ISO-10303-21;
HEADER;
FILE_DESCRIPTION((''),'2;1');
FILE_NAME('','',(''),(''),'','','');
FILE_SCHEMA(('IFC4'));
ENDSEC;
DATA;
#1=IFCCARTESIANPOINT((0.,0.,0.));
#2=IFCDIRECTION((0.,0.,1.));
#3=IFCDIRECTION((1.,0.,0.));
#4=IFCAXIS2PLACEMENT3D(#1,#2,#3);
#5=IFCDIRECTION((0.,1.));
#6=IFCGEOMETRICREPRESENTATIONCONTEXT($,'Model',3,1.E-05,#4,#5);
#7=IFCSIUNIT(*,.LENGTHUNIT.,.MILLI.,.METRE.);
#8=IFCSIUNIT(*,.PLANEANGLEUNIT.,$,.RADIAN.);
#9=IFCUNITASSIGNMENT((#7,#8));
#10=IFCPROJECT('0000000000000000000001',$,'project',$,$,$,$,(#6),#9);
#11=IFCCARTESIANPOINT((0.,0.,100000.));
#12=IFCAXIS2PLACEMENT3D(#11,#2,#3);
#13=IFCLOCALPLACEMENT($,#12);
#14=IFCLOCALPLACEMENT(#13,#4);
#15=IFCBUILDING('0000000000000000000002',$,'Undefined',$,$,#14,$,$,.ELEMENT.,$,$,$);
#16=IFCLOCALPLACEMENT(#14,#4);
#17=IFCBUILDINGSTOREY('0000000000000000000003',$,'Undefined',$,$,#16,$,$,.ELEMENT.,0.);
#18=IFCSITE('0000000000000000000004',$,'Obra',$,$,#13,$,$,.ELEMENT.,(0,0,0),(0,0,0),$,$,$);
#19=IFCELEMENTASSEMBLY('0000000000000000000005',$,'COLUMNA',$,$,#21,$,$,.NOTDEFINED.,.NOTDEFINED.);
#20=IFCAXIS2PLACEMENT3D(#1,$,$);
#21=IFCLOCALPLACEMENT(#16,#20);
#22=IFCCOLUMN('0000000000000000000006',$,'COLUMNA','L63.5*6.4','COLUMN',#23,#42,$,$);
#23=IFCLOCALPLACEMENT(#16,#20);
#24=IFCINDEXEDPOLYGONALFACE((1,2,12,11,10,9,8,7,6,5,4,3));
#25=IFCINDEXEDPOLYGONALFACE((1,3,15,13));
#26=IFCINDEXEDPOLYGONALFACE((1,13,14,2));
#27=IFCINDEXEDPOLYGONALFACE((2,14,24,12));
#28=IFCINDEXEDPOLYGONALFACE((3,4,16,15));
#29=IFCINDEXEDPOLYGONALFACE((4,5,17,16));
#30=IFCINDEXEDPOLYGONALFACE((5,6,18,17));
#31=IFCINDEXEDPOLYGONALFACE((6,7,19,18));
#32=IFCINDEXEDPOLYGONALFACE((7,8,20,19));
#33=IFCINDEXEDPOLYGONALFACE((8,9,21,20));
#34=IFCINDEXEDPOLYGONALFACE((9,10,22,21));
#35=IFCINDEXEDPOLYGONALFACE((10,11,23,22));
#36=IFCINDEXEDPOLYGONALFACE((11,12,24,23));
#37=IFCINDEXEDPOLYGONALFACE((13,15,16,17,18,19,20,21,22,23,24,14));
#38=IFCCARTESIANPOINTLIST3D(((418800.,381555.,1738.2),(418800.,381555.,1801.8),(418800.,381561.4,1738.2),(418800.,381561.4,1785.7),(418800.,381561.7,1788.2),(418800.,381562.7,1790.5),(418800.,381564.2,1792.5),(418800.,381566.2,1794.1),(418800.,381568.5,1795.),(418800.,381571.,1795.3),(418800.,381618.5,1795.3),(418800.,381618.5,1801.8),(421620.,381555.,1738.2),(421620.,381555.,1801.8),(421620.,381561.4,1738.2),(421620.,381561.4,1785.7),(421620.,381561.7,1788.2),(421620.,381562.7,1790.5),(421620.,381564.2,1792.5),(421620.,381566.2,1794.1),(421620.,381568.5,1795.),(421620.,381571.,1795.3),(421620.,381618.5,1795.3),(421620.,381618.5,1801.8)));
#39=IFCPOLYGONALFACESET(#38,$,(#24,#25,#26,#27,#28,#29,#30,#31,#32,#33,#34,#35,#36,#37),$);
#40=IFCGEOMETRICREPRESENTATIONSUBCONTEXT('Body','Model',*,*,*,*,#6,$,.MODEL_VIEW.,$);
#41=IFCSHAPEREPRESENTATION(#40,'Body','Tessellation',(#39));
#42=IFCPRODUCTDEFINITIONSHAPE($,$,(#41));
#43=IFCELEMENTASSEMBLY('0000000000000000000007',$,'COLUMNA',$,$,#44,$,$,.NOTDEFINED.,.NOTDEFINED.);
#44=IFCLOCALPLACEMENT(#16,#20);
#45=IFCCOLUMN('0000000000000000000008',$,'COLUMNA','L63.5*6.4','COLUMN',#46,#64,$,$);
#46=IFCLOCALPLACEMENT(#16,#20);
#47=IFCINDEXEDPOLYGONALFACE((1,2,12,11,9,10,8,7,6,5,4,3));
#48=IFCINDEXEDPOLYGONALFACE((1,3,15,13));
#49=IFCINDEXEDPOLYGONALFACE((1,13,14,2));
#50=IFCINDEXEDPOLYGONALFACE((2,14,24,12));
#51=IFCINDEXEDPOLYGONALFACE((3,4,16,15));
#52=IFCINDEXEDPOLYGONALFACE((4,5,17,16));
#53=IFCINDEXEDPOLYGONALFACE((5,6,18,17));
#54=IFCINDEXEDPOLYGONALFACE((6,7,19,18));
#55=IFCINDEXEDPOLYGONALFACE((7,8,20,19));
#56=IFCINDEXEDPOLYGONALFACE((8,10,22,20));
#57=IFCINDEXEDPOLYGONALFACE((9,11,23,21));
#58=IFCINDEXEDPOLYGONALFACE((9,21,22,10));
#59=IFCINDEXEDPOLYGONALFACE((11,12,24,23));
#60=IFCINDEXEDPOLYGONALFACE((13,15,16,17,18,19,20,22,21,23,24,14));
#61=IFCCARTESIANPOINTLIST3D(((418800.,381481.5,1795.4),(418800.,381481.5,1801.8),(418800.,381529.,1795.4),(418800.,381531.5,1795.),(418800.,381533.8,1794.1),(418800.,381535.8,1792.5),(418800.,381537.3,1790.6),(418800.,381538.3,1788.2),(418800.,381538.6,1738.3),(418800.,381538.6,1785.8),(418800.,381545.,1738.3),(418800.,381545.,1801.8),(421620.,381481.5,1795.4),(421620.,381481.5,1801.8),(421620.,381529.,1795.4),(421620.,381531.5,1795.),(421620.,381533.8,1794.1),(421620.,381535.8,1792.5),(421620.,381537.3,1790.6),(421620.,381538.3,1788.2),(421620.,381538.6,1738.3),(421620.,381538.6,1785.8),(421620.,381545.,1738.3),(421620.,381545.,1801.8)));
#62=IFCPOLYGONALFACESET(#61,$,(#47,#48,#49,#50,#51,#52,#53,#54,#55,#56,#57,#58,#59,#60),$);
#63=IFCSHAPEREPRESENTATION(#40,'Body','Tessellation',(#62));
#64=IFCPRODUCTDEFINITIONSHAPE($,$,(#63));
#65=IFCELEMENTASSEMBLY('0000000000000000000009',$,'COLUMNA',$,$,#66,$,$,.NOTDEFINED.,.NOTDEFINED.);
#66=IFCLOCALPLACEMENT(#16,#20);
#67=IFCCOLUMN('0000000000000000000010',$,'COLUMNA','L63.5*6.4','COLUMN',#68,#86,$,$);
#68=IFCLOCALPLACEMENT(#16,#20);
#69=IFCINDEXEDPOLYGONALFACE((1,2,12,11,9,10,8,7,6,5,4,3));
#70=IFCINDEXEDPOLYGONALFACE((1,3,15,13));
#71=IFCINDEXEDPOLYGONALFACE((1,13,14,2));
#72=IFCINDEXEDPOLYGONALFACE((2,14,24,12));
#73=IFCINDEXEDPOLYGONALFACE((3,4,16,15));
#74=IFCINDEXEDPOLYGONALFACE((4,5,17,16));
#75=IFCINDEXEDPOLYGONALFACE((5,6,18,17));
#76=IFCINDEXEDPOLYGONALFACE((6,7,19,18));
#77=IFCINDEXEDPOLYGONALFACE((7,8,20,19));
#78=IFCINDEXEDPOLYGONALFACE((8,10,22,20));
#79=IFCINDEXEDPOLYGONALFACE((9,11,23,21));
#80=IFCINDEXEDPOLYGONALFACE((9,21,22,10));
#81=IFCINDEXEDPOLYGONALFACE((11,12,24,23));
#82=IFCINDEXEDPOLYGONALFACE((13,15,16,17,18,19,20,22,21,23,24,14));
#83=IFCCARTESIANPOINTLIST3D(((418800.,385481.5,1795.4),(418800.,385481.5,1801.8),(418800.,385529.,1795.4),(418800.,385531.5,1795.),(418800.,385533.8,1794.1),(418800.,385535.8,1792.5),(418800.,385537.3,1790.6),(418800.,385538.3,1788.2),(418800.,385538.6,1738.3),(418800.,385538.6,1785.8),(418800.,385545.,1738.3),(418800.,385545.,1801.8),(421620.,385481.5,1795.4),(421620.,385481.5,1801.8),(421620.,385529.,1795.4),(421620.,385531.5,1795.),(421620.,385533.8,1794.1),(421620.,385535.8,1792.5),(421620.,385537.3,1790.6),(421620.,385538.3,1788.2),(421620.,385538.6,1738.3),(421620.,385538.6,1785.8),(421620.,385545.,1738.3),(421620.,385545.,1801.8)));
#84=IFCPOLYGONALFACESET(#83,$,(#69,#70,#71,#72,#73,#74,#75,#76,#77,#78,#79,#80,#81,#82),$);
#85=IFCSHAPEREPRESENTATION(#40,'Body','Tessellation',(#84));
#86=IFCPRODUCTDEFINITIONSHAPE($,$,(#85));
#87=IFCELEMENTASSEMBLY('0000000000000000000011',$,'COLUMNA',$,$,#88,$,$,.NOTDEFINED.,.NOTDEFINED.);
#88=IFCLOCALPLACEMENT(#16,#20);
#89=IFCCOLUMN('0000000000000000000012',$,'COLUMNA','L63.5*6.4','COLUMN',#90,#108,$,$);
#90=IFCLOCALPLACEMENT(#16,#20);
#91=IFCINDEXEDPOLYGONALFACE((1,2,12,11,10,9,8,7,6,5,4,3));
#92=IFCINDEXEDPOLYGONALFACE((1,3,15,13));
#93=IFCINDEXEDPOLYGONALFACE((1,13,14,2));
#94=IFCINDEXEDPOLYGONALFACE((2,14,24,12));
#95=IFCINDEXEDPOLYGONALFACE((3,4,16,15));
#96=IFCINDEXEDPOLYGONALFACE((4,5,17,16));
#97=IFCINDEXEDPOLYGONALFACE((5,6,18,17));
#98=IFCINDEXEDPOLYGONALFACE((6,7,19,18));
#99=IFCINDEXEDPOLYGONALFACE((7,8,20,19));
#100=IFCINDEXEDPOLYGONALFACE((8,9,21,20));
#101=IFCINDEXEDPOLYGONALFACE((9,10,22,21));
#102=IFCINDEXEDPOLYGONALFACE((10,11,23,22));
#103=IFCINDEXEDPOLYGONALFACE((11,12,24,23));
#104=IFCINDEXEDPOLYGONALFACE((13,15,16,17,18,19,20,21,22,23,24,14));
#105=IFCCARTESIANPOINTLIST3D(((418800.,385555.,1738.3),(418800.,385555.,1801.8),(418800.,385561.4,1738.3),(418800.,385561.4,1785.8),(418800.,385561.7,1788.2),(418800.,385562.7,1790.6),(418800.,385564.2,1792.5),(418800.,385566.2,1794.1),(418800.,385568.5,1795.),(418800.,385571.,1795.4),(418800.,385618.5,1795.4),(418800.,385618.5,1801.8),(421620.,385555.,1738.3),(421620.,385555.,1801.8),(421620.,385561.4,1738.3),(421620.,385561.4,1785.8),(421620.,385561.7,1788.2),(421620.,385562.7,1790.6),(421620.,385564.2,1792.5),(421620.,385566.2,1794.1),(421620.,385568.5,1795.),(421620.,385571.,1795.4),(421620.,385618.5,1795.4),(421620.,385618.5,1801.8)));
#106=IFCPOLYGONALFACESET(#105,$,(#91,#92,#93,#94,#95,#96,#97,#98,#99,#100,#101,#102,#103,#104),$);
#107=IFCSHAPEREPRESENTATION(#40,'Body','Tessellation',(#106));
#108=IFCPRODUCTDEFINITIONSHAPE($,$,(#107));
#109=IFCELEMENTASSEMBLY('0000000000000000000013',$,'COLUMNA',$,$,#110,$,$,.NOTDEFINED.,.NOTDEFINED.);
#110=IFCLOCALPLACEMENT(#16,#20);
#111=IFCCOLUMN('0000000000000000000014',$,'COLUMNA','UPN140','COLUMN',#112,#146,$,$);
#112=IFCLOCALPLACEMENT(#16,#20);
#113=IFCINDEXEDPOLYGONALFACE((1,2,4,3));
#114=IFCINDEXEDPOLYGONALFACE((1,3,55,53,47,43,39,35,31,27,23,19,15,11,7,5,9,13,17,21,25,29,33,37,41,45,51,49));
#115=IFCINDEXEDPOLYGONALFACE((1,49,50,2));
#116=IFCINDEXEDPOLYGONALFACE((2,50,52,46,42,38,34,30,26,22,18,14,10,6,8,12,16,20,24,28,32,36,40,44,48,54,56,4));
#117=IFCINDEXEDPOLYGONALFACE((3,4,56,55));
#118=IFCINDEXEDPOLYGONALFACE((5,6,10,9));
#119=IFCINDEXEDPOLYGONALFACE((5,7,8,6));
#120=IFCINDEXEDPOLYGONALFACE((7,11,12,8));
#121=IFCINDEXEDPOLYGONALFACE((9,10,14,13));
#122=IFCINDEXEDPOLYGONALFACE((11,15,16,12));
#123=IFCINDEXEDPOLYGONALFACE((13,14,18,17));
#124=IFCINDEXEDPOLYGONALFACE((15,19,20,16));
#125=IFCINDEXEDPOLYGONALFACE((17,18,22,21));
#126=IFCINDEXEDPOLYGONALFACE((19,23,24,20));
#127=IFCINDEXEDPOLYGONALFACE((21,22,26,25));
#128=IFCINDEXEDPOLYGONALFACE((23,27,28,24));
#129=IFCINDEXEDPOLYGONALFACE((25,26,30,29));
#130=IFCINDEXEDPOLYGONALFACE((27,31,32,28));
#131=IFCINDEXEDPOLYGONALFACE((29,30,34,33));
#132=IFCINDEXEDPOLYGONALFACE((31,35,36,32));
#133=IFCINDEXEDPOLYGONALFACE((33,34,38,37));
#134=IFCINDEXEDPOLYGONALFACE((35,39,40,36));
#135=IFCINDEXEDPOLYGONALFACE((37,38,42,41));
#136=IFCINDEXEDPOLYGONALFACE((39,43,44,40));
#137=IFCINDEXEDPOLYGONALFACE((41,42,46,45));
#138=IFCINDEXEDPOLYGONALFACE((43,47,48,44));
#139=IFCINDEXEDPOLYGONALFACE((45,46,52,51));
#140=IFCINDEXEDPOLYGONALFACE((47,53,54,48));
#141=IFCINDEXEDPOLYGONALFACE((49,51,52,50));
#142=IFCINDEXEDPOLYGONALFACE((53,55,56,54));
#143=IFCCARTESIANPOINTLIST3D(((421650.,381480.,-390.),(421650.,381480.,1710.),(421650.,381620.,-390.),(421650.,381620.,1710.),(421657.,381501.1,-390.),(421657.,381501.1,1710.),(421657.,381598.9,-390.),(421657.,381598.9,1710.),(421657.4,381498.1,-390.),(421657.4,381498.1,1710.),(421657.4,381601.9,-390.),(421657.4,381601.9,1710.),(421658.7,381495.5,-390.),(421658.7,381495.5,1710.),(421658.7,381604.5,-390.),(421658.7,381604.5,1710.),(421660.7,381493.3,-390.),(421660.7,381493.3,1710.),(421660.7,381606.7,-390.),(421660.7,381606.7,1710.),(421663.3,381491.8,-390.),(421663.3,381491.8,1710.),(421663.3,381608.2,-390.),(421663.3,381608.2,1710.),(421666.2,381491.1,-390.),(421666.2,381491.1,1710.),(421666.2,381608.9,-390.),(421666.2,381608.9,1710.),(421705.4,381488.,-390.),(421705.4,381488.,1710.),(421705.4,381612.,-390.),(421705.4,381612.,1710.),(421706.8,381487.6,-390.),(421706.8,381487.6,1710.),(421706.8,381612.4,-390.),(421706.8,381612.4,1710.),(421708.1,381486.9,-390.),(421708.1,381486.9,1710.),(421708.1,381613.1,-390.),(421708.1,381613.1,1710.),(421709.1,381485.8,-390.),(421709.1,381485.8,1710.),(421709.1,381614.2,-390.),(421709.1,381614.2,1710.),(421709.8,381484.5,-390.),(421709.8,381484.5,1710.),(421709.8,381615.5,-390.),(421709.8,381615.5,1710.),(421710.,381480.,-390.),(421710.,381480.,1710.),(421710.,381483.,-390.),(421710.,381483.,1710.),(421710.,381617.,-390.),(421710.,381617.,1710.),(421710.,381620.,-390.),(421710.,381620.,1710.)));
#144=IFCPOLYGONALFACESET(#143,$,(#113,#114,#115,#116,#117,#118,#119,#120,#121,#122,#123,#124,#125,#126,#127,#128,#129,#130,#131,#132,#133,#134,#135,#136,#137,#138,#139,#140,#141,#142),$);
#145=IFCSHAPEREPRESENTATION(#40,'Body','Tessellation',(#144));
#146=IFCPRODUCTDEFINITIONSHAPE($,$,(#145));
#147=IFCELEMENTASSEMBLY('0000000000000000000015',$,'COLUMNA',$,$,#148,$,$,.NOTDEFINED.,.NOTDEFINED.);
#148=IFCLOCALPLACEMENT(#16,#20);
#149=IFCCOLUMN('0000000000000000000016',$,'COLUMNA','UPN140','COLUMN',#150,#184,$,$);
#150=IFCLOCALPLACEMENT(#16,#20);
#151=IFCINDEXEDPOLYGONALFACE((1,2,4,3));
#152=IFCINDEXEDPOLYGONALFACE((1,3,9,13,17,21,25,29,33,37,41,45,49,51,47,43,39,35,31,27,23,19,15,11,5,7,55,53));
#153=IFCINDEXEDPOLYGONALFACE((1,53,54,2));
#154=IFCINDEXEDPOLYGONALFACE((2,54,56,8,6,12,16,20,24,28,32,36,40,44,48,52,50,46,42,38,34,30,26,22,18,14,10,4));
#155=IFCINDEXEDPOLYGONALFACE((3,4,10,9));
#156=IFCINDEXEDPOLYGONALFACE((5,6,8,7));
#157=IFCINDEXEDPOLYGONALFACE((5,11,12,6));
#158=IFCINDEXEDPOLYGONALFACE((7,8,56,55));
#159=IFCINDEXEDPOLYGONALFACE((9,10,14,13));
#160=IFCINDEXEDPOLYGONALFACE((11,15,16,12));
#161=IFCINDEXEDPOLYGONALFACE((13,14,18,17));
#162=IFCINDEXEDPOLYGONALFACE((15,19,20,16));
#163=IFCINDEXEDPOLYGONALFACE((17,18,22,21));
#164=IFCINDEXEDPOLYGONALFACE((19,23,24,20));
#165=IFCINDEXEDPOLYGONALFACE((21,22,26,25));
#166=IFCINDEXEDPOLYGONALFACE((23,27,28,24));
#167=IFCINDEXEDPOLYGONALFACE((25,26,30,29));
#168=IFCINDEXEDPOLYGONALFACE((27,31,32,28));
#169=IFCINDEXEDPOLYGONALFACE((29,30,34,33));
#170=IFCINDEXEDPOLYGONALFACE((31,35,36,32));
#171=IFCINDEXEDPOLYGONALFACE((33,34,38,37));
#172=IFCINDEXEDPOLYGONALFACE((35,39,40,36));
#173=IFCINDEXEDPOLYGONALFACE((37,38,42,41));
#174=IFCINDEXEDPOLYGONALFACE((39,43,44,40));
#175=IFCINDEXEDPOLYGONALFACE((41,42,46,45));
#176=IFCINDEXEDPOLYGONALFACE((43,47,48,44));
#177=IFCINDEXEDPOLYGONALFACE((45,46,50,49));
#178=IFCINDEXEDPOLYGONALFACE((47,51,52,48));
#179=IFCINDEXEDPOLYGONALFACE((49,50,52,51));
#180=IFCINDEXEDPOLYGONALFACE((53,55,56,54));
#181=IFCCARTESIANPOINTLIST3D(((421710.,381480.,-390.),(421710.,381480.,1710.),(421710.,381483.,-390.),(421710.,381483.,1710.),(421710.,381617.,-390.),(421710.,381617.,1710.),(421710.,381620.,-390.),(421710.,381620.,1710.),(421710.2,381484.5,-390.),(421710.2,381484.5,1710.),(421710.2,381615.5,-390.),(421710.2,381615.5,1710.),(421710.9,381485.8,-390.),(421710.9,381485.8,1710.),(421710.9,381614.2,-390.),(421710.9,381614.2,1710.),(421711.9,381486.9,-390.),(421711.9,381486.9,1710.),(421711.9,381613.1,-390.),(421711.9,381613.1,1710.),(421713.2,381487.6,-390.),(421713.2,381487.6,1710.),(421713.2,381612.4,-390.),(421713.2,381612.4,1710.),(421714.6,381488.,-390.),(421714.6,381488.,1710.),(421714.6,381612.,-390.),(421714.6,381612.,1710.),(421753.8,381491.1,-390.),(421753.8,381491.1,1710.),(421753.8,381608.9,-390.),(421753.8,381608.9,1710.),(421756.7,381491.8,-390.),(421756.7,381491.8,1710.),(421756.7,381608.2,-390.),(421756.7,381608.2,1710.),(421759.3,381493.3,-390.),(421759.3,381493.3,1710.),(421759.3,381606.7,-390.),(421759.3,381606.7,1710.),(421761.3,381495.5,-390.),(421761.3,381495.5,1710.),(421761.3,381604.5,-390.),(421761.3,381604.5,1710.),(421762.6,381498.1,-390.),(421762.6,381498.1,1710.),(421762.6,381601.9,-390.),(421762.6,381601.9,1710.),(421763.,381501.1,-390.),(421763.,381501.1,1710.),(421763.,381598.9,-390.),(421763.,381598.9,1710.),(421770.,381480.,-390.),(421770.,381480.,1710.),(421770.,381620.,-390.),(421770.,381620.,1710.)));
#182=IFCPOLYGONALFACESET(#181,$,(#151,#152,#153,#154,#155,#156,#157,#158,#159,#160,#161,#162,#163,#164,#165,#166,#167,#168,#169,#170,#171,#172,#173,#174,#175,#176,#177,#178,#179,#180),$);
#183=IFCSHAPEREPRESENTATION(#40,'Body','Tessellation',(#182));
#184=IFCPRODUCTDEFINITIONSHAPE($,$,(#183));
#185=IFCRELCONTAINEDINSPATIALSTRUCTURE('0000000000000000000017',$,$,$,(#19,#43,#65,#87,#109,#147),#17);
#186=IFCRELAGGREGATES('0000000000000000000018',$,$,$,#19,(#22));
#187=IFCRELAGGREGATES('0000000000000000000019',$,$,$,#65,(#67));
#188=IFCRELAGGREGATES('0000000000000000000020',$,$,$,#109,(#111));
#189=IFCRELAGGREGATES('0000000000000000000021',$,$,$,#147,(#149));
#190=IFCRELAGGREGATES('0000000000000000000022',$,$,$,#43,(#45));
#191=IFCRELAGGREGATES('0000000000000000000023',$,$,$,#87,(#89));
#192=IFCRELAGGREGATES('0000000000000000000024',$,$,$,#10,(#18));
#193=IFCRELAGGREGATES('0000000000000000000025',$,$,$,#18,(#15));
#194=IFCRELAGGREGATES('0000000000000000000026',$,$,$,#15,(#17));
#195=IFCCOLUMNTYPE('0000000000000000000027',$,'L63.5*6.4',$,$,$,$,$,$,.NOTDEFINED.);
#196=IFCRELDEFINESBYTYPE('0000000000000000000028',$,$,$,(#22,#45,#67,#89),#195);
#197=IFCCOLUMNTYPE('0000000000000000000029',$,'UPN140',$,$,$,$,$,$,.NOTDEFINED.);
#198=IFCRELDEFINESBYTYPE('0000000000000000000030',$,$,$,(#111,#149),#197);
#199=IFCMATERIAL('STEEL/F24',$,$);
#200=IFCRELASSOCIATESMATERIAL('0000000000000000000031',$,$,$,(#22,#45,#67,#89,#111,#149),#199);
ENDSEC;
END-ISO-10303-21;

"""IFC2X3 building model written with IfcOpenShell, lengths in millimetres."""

from ifc_helpers import new_model, si_unit, direction, frame, origin_with_axes, origin_2d_with_axis, place, context, subcontext, project, spatial, l_section, u_section, extrude, material, type_object, element, aggregate, save


model = new_model("IFC2X3")

# Units and contexts
model_context = context("Model", 3, precision=1e-05, world=origin_with_axes(), true_north=direction((0.0, 1.0)))
body_context = subcontext(model_context, "Body", "Model", "MODEL_VIEW")
ifc_project = project(units=[si_unit("LENGTHUNIT", "METRE", prefix="MILLI"), si_unit("PLANEANGLEUNIT", "RADIAN")], contexts=[model_context])

# Site, building, storey
site_placement = place(None, frame((0.0, 0.0, 100000.0), z_axis=(0.0, 0.0, 1.0), x_axis=(1.0, 0.0, 0.0)))
site = spatial("IfcSite", under=ifc_project, at=site_placement, Name="Obra", CompositionType="ELEMENT", RefLatitude=(0, 0, 0), RefLongitude=(0, 0, 0))
building_placement = place(site_placement, origin_with_axes())
building = spatial("IfcBuilding", under=site, at=building_placement, Name="Undefined", CompositionType="ELEMENT")
storey_placement = place(building_placement, origin_with_axes())
storey = spatial("IfcBuildingStorey", under=building, at=storey_placement, Name="Undefined", CompositionType="ELEMENT", Elevation=0.0)

# Element assemblies, columns
assembly_1_placement = place(storey_placement, origin_with_axes())
assembly_1 = element("IfcElementAssembly", 1, at=assembly_1_placement, inside=storey, Name="COLUMNA", AssemblyPlace="NOTDEFINED", PredefinedType="NOTDEFINED")
ifc_material_1 = material(Name="STEEL/F24")
column_type_1 = type_object("IfcColumnType", Name="L63.5*6.4", PredefinedType="NOTDEFINED")
column_1_placement = place(assembly_1_placement, frame((418800.0, 381586.7, 1770.0), z_axis=(1.0, 0.0, 0.0), x_axis=(0.0, 0.0, -1.0)))
column_1 = element("IfcColumn", 2, at=column_1_placement, type_object=column_type_1, material=ifc_material_1, Name="COLUMNA", Description="L63.5*6.4", ObjectType="COLUMN", context=body_context, shape_type="SweptSolid", body=[
    extrude(l_section(Depth=63.5, Width=63.5, Thickness=6.4, FilletRadius=9.6, at=origin_2d_with_axis()), frame((0.0, 0.0, 2820.0), z_axis=(0.0, 0.0, -1.0), x_axis=(0.0, 1.0, 0.0)), (0.0, 0.0, 1.0), 2820.0),
])
aggregate(assembly_1, [column_1])
assembly_2_placement = place(storey_placement, origin_with_axes())
assembly_2 = element("IfcElementAssembly", 3, at=assembly_2_placement, inside=storey, Name="COLUMNA", AssemblyPlace="NOTDEFINED", PredefinedType="NOTDEFINED")
column_2_placement = place(assembly_2_placement, frame((418800.0, 381513.2, 1770.0), z_axis=(1.0, 0.0, 0.0), x_axis=(0.0, -1.0, 0.0)))
column_2 = element("IfcColumn", 4, at=column_2_placement, type_object=column_type_1, material=ifc_material_1, Name="COLUMNA", Description="L63.5*6.4", ObjectType="COLUMN", context=body_context, shape_type="SweptSolid", body=[
    extrude(l_section(Depth=63.5, Width=63.5, Thickness=6.4, FilletRadius=9.6, at=origin_2d_with_axis()), frame((0.0, 0.0, 2820.0), z_axis=(0.0, 0.0, -1.0), x_axis=(0.0, 1.0, 0.0)), (0.0, 0.0, 1.0), 2820.0),
])
assembly_3_placement = place(storey_placement, origin_with_axes())
assembly_3 = element("IfcElementAssembly", 5, at=assembly_3_placement, inside=storey, Name="COLUMNA", AssemblyPlace="NOTDEFINED", PredefinedType="NOTDEFINED")
column_3_placement = place(assembly_3_placement, frame((421620.0, 385513.2, 1770.0), z_axis=(-1.0, 0.0, 0.0), x_axis=(0.0, 0.0, -1.0)))
column_3 = element("IfcColumn", 6, at=column_3_placement, type_object=column_type_1, material=ifc_material_1, Name="COLUMNA", Description="L63.5*6.4", ObjectType="COLUMN", context=body_context, shape_type="SweptSolid", body=[
    extrude(l_section(Depth=63.5, Width=63.5, Thickness=6.4, FilletRadius=9.6, at=origin_2d_with_axis()), frame((0.0, 0.0, 2820.0), z_axis=(0.0, 0.0, -1.0), x_axis=(0.0, 1.0, 0.0)), (0.0, 0.0, 1.0), 2820.0),
])
aggregate(assembly_3, [column_3])
assembly_4_placement = place(storey_placement, origin_with_axes())
assembly_4 = element("IfcElementAssembly", 7, at=assembly_4_placement, inside=storey, Name="COLUMNA", AssemblyPlace="NOTDEFINED", PredefinedType="NOTDEFINED")
column_4_placement = place(assembly_4_placement, frame((421620.0, 385586.7, 1770.0), z_axis=(-1.0, 0.0, 0.0), x_axis=(0.0, 1.0, 0.0)))
column_4 = element("IfcColumn", 8, at=column_4_placement, type_object=column_type_1, material=ifc_material_1, Name="COLUMNA", Description="L63.5*6.4", ObjectType="COLUMN", context=body_context, shape_type="SweptSolid", body=[
    extrude(l_section(Depth=63.5, Width=63.5, Thickness=6.4, FilletRadius=9.6, at=origin_2d_with_axis()), frame((0.0, 0.0, 2820.0), z_axis=(0.0, 0.0, -1.0), x_axis=(0.0, 1.0, 0.0)), (0.0, 0.0, 1.0), 2820.0),
])
assembly_5_placement = place(storey_placement, origin_with_axes())
assembly_5 = element("IfcElementAssembly", 9, at=assembly_5_placement, inside=storey, Name="COLUMNA", AssemblyPlace="NOTDEFINED", PredefinedType="NOTDEFINED")
column_type_2 = type_object("IfcColumnType", Name="UPN140", PredefinedType="NOTDEFINED")
column_5_placement = place(assembly_5_placement, frame((421680.0, 381550.0, 1710.0), z_axis=(0.0, 0.0, -1.0), x_axis=(0.0, 1.0, 0.0)))
column_5 = element("IfcColumn", 10, at=column_5_placement, type_object=column_type_2, material=ifc_material_1, Name="COLUMNA", Description="UPN140", ObjectType="COLUMN", context=body_context, shape_type="SweptSolid", body=[
    extrude(u_section(Depth=140.0, FlangeWidth=60.0, WebThickness=7.0, FlangeThickness=10.0, FilletRadius=10.0, EdgeRadius=5.0, FlangeSlope=0.07983, at=origin_2d_with_axis()), frame((0.0, 0.0, 2100.0), z_axis=(0.0, 0.0, -1.0), x_axis=(0.0, 1.0, 0.0)), (0.0, 0.0, 1.0), 2100.0),
])
aggregate(assembly_5, [column_5])
assembly_6_placement = place(storey_placement, origin_with_axes())
assembly_6 = element("IfcElementAssembly", 11, at=assembly_6_placement, inside=storey, Name="COLUMNA", AssemblyPlace="NOTDEFINED", PredefinedType="NOTDEFINED")
column_6_placement = place(assembly_6_placement, frame((421740.0, 381550.0, 1710.0), z_axis=(0.0, 0.0, -1.0), x_axis=(0.0, -1.0, 0.0)))
column_6 = element("IfcColumn", 12, at=column_6_placement, type_object=column_type_2, material=ifc_material_1, Name="COLUMNA", Description="UPN140", ObjectType="COLUMN", context=body_context, shape_type="SweptSolid", body=[
    extrude(u_section(Depth=140.0, FlangeWidth=60.0, WebThickness=7.0, FlangeThickness=10.0, FilletRadius=10.0, EdgeRadius=5.0, FlangeSlope=0.07983, at=origin_2d_with_axis()), frame((0.0, 0.0, 2100.0), z_axis=(0.0, 0.0, -1.0), x_axis=(0.0, 1.0, 0.0)), (0.0, 0.0, 1.0), 2100.0),
])
aggregate(assembly_6, [column_6])

aggregate(assembly_2, [column_2])
aggregate(assembly_4, [column_4])

save(model, "model.ifc")
